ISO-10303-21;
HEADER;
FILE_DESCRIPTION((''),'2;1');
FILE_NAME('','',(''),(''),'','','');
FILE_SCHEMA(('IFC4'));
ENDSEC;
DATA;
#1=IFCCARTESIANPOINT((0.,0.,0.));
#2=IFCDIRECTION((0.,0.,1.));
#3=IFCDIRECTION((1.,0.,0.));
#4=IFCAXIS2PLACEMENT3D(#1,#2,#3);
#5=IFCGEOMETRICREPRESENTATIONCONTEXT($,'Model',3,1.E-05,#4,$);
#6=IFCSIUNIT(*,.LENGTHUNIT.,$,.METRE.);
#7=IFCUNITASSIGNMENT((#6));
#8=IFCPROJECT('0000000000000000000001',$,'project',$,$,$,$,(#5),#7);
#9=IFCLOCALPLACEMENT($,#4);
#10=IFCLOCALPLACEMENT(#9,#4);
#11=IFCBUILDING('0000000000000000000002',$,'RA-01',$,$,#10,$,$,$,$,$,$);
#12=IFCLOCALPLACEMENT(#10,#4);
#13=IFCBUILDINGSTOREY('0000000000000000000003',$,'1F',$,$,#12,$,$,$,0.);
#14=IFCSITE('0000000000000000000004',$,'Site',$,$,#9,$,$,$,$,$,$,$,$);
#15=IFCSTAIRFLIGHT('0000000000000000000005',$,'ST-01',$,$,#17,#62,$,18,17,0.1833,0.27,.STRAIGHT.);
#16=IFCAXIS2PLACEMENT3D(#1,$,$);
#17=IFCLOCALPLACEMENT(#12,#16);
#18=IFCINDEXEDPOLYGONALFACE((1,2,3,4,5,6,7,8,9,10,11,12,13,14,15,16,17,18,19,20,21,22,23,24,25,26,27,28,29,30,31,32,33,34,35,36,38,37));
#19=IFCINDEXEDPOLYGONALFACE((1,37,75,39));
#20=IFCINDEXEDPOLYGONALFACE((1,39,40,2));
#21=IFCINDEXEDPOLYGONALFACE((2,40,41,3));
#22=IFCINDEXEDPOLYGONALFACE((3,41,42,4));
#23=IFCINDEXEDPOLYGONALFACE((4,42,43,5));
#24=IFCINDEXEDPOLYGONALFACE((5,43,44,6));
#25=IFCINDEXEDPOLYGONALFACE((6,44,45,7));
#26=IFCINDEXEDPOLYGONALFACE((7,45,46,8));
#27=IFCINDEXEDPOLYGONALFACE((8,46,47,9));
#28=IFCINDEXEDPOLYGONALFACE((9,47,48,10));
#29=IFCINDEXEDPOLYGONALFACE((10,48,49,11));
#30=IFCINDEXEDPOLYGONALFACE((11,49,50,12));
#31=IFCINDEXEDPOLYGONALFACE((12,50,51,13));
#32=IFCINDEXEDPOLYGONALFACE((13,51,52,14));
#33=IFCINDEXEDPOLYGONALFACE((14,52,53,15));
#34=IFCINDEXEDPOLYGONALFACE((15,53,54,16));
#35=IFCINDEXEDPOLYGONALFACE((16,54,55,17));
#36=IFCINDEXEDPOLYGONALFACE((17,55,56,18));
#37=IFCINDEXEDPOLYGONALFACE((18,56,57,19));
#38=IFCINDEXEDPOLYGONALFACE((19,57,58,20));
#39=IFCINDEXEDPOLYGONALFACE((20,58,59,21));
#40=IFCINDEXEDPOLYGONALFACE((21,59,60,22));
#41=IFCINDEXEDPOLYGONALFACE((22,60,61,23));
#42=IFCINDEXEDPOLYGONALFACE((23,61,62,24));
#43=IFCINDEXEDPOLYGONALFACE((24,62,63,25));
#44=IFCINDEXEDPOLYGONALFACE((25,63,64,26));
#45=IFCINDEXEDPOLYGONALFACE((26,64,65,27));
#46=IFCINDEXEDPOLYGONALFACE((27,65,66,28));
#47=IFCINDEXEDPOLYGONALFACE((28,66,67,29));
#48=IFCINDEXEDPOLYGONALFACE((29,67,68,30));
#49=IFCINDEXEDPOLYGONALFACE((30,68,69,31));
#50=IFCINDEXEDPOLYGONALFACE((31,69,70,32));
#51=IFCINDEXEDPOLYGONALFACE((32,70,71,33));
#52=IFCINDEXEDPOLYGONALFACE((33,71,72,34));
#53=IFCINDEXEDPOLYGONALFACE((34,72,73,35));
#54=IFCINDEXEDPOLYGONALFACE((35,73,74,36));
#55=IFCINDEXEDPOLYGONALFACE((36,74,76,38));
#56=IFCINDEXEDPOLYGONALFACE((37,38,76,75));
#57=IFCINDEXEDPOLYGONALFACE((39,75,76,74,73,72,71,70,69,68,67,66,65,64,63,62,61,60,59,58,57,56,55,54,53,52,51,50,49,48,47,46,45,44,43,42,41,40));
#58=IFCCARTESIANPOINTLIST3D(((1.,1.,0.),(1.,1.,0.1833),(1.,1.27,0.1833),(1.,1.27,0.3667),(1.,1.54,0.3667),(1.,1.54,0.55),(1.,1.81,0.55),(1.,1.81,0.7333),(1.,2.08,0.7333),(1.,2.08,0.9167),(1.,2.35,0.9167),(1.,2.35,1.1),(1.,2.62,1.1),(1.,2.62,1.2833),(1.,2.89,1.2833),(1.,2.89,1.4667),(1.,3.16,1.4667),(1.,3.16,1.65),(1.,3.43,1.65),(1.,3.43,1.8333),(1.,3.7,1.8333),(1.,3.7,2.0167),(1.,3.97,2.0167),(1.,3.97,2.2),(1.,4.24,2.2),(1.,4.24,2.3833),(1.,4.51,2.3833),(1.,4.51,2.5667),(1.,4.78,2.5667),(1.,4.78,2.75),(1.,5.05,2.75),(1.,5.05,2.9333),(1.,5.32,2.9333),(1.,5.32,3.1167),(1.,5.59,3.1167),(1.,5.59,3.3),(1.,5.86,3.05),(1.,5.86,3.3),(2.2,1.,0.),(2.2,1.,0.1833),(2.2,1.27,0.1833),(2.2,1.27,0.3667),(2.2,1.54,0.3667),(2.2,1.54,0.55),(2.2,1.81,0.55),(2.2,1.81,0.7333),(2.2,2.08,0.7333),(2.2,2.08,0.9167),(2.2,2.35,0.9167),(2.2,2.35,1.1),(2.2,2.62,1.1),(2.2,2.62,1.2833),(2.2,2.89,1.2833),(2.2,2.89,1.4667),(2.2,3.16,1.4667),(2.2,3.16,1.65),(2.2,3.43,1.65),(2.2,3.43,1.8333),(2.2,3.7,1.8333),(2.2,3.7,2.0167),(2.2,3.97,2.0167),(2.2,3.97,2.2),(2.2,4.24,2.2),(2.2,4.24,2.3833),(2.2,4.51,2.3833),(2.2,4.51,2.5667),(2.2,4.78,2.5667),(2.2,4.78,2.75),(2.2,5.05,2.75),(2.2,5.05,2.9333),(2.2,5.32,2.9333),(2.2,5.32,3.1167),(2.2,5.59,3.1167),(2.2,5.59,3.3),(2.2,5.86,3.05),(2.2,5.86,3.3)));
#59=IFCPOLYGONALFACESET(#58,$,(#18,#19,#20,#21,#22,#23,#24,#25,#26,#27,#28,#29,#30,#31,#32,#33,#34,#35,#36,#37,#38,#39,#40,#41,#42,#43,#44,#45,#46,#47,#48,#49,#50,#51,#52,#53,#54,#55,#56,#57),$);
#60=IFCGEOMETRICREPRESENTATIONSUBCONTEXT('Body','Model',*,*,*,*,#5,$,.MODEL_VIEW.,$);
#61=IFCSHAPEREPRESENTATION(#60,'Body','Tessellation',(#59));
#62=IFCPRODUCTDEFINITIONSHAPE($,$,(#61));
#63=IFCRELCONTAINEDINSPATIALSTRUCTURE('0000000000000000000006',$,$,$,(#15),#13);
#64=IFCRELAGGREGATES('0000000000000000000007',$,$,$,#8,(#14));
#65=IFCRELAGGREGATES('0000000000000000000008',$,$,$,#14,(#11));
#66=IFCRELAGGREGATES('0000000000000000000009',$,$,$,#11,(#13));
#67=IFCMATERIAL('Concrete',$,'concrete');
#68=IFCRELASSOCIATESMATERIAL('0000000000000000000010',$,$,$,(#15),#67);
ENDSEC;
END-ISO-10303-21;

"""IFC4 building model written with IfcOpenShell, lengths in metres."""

from ifc_helpers import new_model, si_unit, frame, origin_with_axes, place, context, subcontext, project, spatial, polyline, outline, extrude, material, element, save


model = new_model("IFC4")

# Units and contexts
model_context = context("Model", 3, precision=1e-05, world=origin_with_axes())
body_context = subcontext(model_context, "Body", "Model", "MODEL_VIEW")
ifc_project = project(units=[si_unit("LENGTHUNIT", "METRE")], contexts=[model_context])

# Site, building, storey
site_placement = place(None, origin_with_axes())
site = spatial("IfcSite", under=ifc_project, at=site_placement, Name="Site")
building_placement = place(site_placement, origin_with_axes())
building = spatial("IfcBuilding", under=site, at=building_placement, Name="RA-01")
storey_placement = place(building_placement, origin_with_axes())
storey = spatial("IfcBuildingStorey", under=building, at=storey_placement, Name="1F", Elevation=0.0)

# Shared definitions
ifc_material_1 = material(Name="Concrete", Category="concrete")

# Stair flight
stair_flight_placement = place(storey_placement, frame((1.0, 1.0, 0.0), z_axis=(1.0, 0.0, 0.0), x_axis=(0.0, 1.0, 0.0)))
element("IfcStairFlight", 1, at=stair_flight_placement, inside=storey, material=ifc_material_1, Name="ST-01", NumberOfRisers=18, NumberOfTreads=17, PredefinedType="STRAIGHT", RiserHeight=0.1833, TreadLength=0.27, context=body_context, shape_type="SweptSolid", body=[
    extrude(outline(polyline([(0.0, 0.0), (0.0, 0.1833), (0.27, 0.1833), (0.27, 0.3667), (0.54, 0.3667), (0.54, 0.55), (0.81, 0.55), (0.81, 0.7333), (1.08, 0.7333), (1.08, 0.9167), (1.35, 0.9167), (1.35, 1.1), (1.62, 1.1), (1.62, 1.2833), (1.89, 1.2833), (1.89, 1.4667), (2.16, 1.4667), (2.16, 1.65), (2.43, 1.65), (2.43, 1.8333), (2.7, 1.8333), (2.7, 2.0167), (2.97, 2.0167), (2.97, 2.2), (3.24, 2.2), (3.24, 2.3833), (3.51, 2.3833), (3.51, 2.5667), (3.78, 2.5667), (3.78, 2.75), (4.05, 2.75), (4.05, 2.9333), (4.32, 2.9333), (4.32, 3.1167), (4.59, 3.1167), (4.59, 3.3), (4.86, 3.3), (4.86, 3.05), (0.0, 0.0)])), origin_with_axes(), (0.0, 0.0, 1.0), 1.2),
])

save(model, "model.ifc")
